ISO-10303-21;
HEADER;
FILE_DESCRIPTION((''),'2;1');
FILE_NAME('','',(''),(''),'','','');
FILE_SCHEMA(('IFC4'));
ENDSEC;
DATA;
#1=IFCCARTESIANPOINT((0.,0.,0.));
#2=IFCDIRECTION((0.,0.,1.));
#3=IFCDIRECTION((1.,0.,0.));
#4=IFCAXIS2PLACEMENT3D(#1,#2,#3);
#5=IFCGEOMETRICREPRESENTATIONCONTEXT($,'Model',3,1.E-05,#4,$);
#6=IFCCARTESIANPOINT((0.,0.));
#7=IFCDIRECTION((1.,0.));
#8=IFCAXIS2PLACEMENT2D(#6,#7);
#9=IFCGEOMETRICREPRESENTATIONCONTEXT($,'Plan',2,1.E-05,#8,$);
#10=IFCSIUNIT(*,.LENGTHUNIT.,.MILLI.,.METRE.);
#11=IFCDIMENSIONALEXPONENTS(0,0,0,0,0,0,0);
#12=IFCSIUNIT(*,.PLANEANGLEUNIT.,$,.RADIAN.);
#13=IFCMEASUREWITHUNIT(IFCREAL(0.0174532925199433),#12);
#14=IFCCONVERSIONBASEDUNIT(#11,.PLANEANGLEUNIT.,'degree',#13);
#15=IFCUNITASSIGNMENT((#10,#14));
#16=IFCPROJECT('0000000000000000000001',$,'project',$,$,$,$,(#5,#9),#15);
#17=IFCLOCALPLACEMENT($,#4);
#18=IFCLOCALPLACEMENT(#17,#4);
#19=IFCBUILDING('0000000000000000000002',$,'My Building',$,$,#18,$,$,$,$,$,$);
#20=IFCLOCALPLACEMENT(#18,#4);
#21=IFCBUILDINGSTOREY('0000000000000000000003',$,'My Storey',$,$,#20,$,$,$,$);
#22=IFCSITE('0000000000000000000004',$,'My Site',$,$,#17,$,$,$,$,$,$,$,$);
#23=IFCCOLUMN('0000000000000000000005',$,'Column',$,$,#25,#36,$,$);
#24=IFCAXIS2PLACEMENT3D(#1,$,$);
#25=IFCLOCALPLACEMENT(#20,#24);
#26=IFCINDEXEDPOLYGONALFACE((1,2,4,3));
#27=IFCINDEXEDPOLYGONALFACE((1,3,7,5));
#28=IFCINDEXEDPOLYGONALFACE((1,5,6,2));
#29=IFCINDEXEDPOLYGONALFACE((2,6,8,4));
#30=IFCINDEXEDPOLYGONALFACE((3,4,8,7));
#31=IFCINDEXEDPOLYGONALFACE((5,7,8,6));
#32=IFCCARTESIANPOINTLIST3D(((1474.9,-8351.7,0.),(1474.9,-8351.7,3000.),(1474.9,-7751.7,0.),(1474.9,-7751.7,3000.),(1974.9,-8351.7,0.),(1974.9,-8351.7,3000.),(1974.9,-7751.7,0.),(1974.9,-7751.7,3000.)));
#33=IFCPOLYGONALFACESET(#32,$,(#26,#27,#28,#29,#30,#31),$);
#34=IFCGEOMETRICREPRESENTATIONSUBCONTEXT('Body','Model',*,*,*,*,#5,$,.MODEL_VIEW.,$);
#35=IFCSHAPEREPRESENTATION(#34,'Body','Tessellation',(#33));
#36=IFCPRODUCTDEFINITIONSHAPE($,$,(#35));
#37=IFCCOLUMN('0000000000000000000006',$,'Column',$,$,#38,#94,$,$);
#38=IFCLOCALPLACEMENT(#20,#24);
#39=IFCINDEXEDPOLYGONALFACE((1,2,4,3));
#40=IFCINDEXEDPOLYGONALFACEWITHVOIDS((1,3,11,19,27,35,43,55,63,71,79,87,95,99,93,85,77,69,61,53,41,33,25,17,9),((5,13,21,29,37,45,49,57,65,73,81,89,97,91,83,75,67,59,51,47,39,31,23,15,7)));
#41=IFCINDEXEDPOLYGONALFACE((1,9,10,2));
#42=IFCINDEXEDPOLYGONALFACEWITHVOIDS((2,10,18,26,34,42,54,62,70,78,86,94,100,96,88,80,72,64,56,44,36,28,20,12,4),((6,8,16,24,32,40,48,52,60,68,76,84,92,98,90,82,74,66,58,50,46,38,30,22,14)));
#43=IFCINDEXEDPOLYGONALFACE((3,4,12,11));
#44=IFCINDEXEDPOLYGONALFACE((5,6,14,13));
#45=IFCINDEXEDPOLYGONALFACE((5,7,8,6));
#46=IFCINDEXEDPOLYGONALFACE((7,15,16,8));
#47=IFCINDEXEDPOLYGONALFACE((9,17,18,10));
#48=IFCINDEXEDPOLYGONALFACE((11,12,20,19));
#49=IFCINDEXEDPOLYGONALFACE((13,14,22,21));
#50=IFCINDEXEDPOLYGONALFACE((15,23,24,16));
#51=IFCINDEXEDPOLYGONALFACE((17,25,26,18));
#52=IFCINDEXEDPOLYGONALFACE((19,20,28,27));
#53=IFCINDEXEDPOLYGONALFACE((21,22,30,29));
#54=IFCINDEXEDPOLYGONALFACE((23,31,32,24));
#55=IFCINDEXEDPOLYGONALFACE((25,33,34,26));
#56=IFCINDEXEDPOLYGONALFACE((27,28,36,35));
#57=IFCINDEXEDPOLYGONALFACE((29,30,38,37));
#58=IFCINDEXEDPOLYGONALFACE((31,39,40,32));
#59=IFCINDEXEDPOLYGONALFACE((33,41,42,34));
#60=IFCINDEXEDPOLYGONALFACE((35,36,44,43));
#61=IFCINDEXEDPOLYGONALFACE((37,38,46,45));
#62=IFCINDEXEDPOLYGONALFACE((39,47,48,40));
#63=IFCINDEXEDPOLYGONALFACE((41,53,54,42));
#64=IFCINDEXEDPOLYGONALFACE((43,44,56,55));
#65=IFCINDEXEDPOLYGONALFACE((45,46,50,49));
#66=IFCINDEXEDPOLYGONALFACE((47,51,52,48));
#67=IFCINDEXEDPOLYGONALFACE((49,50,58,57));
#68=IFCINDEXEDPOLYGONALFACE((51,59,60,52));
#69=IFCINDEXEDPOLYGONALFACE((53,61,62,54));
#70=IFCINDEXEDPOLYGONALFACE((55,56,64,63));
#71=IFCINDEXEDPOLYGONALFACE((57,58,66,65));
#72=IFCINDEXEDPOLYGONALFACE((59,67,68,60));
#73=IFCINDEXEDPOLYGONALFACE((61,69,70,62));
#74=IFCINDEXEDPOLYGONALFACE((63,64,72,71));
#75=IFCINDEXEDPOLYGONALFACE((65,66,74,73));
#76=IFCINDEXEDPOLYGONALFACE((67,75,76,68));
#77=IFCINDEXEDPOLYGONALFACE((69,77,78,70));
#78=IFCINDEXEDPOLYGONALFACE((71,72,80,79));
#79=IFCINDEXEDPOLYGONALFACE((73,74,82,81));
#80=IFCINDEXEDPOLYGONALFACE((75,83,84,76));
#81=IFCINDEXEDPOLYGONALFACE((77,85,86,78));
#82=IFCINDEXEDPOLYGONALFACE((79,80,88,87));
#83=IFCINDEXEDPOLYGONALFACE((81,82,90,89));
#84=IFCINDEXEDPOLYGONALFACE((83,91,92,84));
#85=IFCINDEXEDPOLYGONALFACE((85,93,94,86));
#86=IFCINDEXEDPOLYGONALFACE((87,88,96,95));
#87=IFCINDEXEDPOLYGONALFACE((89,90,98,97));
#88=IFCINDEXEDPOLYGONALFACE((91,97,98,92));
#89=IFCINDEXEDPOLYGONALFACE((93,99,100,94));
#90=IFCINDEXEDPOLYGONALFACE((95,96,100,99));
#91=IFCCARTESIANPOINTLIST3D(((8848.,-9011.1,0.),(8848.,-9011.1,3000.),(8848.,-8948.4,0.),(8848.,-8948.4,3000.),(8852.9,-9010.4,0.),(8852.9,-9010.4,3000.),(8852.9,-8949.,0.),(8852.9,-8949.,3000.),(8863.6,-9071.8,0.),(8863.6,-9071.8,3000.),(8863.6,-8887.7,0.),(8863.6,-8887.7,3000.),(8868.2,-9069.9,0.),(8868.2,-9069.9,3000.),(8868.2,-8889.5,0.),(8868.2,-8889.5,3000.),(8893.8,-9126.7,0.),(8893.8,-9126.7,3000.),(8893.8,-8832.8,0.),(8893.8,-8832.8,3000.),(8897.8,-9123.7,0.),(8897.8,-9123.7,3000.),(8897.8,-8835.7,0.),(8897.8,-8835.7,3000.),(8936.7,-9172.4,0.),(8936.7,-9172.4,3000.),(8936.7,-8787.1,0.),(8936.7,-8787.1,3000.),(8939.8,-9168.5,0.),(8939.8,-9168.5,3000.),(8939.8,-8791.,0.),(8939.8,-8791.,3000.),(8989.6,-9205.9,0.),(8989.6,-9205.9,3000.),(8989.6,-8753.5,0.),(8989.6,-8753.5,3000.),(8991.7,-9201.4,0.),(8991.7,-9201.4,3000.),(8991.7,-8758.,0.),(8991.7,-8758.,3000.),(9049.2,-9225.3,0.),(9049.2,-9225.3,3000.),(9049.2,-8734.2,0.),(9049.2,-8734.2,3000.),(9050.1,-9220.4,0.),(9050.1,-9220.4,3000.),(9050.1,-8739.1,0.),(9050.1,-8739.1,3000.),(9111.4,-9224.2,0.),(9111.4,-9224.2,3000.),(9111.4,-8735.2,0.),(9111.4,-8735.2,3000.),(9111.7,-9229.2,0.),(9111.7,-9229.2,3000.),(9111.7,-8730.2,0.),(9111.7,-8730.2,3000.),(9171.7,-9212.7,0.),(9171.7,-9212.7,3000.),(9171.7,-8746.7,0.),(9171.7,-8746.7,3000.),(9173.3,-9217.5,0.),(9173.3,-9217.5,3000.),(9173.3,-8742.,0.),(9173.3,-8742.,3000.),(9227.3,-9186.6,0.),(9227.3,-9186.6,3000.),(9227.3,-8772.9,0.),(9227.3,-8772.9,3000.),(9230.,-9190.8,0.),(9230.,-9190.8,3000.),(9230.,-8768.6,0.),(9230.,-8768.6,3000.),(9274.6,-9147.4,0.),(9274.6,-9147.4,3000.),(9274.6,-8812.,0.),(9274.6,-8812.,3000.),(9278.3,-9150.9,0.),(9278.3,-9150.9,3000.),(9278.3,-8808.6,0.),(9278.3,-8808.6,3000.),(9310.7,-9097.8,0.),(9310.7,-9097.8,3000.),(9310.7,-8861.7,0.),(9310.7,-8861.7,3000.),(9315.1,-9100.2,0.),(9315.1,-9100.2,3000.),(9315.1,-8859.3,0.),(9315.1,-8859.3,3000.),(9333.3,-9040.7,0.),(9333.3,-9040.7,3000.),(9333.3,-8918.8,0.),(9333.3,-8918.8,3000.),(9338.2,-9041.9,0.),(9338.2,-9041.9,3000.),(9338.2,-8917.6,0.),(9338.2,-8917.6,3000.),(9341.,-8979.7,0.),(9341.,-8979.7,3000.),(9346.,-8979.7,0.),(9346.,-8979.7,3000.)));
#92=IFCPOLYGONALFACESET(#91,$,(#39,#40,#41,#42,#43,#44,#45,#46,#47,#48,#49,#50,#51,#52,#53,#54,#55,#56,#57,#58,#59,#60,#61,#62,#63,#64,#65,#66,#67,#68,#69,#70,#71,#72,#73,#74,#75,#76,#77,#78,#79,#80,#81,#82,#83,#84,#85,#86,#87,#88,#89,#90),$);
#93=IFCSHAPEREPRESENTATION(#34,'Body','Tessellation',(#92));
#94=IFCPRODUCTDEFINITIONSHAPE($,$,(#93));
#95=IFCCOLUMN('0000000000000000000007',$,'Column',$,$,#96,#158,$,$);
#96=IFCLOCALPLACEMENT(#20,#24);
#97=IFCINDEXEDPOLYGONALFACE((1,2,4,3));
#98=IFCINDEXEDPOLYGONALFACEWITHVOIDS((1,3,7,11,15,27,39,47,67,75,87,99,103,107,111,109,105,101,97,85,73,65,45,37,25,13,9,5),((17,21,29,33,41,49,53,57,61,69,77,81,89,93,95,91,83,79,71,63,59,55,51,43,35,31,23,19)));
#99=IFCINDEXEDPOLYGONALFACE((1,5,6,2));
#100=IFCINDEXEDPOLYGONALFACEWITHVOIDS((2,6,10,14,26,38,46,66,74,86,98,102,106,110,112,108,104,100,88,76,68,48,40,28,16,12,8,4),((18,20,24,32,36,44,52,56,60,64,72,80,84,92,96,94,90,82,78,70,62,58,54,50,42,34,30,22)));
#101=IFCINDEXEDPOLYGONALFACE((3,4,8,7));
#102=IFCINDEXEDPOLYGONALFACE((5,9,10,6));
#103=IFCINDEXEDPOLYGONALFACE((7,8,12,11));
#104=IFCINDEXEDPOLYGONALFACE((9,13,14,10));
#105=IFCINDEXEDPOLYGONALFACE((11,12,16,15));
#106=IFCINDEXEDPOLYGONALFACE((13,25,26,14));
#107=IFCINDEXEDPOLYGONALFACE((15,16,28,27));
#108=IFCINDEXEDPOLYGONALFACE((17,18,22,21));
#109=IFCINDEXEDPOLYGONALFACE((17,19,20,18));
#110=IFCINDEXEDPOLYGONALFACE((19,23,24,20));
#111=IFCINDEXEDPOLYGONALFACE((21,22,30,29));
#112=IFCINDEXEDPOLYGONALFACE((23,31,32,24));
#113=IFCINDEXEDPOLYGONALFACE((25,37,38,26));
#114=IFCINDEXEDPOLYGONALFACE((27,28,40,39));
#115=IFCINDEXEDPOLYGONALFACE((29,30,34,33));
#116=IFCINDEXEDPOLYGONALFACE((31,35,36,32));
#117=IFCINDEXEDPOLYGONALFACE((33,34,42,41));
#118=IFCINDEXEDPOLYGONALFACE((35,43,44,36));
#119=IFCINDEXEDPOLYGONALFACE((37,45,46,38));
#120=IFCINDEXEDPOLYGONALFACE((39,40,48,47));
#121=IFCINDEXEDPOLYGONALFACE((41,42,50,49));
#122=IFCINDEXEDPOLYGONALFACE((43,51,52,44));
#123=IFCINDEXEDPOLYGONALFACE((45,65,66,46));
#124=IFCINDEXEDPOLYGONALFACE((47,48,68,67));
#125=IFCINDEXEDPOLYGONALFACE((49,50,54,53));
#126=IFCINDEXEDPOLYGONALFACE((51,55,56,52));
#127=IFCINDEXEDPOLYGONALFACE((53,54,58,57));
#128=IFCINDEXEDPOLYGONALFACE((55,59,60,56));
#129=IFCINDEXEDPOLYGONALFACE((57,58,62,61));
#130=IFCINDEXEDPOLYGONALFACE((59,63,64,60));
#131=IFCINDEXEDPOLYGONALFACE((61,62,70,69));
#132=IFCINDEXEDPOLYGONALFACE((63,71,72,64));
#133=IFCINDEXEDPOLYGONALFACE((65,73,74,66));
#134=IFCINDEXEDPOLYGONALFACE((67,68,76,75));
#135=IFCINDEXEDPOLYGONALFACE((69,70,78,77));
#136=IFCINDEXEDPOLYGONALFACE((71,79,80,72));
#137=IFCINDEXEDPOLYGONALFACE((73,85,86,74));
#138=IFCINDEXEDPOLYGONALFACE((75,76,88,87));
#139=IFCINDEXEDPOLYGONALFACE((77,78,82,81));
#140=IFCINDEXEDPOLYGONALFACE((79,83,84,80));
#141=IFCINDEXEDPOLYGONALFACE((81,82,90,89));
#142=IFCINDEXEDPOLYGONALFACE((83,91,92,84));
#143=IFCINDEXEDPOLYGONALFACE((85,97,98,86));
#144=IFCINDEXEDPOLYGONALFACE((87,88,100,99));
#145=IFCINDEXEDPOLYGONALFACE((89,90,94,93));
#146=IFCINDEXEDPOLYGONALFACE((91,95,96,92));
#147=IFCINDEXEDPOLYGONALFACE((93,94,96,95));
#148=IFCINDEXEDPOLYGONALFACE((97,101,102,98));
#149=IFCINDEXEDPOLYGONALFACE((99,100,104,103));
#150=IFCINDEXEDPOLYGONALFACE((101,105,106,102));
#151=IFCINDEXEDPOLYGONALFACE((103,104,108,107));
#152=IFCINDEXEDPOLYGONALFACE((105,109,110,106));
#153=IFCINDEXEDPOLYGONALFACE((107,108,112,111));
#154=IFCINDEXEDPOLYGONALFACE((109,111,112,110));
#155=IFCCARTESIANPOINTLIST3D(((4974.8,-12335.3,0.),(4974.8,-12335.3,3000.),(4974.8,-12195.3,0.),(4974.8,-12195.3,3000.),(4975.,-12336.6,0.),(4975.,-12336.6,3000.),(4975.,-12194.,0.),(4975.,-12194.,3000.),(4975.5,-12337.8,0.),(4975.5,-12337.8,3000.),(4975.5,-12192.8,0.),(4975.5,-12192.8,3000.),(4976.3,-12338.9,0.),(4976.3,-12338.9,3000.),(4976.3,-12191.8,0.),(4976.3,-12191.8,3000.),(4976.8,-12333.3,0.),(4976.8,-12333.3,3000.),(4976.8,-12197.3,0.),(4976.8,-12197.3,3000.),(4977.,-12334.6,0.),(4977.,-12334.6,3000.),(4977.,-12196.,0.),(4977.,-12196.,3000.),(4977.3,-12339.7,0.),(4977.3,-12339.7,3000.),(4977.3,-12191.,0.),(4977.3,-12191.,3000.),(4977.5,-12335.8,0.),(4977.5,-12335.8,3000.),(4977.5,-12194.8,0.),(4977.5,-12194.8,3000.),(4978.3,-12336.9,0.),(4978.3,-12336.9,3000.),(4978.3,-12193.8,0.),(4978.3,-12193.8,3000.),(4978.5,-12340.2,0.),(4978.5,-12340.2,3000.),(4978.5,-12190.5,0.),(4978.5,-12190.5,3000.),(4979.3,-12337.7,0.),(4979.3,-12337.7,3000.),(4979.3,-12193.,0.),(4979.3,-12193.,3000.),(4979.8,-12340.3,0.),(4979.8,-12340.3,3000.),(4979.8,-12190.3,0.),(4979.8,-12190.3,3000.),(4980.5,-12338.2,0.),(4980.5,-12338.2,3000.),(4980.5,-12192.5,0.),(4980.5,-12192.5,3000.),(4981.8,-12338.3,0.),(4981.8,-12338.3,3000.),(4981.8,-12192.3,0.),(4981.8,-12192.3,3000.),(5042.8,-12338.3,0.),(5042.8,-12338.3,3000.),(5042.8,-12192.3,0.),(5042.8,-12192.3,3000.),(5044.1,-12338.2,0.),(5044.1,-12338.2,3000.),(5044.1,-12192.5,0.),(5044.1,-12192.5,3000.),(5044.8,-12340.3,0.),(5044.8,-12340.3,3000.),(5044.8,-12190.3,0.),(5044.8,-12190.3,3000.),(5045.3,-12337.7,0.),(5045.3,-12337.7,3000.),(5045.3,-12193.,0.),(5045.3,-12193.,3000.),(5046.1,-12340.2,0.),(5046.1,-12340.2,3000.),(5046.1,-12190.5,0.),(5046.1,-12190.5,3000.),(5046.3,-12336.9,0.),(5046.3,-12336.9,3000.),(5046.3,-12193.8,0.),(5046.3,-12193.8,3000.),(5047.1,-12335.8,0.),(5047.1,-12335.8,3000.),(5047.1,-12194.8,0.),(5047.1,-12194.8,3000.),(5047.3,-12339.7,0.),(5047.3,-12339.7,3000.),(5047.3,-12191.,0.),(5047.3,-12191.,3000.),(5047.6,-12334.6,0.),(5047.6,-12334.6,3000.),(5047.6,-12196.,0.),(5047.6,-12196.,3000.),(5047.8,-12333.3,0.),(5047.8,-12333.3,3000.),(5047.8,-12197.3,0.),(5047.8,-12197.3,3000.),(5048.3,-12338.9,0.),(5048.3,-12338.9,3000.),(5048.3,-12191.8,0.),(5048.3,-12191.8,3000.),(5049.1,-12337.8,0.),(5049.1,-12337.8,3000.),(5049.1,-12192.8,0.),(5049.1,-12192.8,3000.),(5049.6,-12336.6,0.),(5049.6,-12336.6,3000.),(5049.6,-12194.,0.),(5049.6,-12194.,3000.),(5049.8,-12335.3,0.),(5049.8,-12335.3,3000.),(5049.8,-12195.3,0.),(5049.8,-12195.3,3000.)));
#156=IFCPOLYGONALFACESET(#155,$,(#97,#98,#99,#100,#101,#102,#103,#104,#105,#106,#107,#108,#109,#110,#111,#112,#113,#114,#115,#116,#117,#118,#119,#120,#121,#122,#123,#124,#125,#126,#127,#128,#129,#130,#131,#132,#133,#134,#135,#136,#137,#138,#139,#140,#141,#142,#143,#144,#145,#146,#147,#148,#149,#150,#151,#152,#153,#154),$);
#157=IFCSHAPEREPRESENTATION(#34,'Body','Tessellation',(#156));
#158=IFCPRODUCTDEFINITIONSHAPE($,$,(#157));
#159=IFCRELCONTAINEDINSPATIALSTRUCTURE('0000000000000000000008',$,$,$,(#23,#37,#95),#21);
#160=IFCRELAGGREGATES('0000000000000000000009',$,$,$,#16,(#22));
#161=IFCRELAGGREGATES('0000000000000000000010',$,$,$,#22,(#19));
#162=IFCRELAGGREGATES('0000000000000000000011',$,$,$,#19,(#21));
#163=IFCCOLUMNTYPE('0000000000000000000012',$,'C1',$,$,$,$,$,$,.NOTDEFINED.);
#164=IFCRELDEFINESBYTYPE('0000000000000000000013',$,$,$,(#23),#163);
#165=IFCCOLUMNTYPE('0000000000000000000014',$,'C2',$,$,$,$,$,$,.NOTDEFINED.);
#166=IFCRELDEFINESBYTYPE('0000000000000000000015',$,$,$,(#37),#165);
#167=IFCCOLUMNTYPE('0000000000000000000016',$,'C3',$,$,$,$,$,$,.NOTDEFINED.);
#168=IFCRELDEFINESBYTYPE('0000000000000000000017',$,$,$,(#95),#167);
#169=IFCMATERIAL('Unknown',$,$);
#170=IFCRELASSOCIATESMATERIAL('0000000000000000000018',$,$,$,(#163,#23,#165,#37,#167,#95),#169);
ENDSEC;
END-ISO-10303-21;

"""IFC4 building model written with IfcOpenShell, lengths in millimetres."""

from ifc_helpers import new_model, entity, si_unit, converted_unit, frame, origin_with_axes, origin_2d_with_axis, place, context, subcontext, project, spatial, rectangle, hollow_rectangle, hollow_circle, extrude, material, material_profile, profile_set, profile_usage, type_object, element, save


model = new_model("IFC4")

# Units and contexts
model_context = context("Model", 3, precision=1e-05, world=origin_with_axes())
plan_context = context("Plan", 2, precision=1e-05, world=origin_2d_with_axis())
body_context_1 = subcontext(model_context, "Body", "Model", "MODEL_VIEW")
ifc_project = project(units=[si_unit("LENGTHUNIT", "METRE", prefix="MILLI"), converted_unit("PLANEANGLEUNIT", "degree", entity("IfcReal", 0.0174532925199433), si_unit("PLANEANGLEUNIT", "RADIAN"), dimensions=[0, 0, 0, 0, 0, 0, 0])], contexts=[model_context, plan_context])

# Site, building, storey
site_placement = place(None, origin_with_axes())
site = spatial("IfcSite", under=ifc_project, at=site_placement, Name="My Site")
building_placement = place(site_placement, origin_with_axes())
building = spatial("IfcBuilding", under=site, at=building_placement, Name="My Building")
storey_placement = place(building_placement, origin_with_axes())
storey = spatial("IfcBuildingStorey", under=building, at=storey_placement, Name="My Storey")

# Columns
ifc_material = material(Name="Unknown")
ifc_material_profile_1 = material_profile(ifc_material, rectangle(XDim=500.0, YDim=600.0))
ifc_profile_set_1 = profile_set([ifc_material_profile_1])
ifc_profile_usage_1 = profile_usage(ifc_profile_set_1)
column_type_1 = type_object("IfcColumnType", Name="C1", PredefinedType="NOTDEFINED", material=ifc_profile_set_1)
column_1_placement = place(storey_placement, frame((1724.9, -8051.7, 0.0), z_axis=(0.0, 0.0, 1.0), x_axis=(1.0, 0.0, 0.0)))
element("IfcColumn", 1, at=column_1_placement, inside=storey, type_object=column_type_1, material=ifc_profile_usage_1, Name="Column", context=body_context_1, shape_type="SweptSolid", body=[
    extrude(rectangle(XDim=500.0, YDim=600.0), origin_with_axes(), (0.0, 0.0, 1.0), 3000.0),
])
ifc_material_profile_2 = material_profile(ifc_material, hollow_circle(Radius=250.0, WallThickness=5.0))
ifc_profile_set_2 = profile_set([ifc_material_profile_2])
ifc_profile_usage_2 = profile_usage(ifc_profile_set_2, cardinal=5)
column_type_2 = type_object("IfcColumnType", Name="C2", PredefinedType="NOTDEFINED", material=ifc_profile_set_2)
column_2_placement = place(storey_placement, frame((9096.0, -8979.7, 0.0), z_axis=(0.0, 0.0, 1.0), x_axis=(1.0, 0.0, 0.0)))
element("IfcColumn", 2, at=column_2_placement, inside=storey, type_object=column_type_2, material=ifc_profile_usage_2, Name="Column", context=body_context_1, shape_type="SweptSolid", body=[
    extrude(hollow_circle(Radius=250.0, WallThickness=5.0), origin_with_axes(), (0.0, 0.0, 1.0), 3000.0),
])
ifc_material_profile_3 = material_profile(ifc_material, hollow_rectangle(XDim=75.0, YDim=150.0, WallThickness=2.0, InnerFilletRadius=5.0, OuterFilletRadius=5.0))
ifc_profile_set_3 = profile_set([ifc_material_profile_3])
ifc_profile_usage_3 = profile_usage(ifc_profile_set_3)
column_type_3 = type_object("IfcColumnType", Name="C3", PredefinedType="NOTDEFINED", material=ifc_profile_set_3)
column_3_placement = place(storey_placement, frame((5012.3, -12265.3, 0.0), z_axis=(0.0, 0.0, 1.0), x_axis=(1.0, 0.0, 0.0)))
element("IfcColumn", 3, at=column_3_placement, inside=storey, type_object=column_type_3, material=ifc_profile_usage_3, Name="Column", context=body_context_1, shape_type="SweptSolid", body=[
    extrude(hollow_rectangle(XDim=75.0, YDim=150.0, WallThickness=2.0, InnerFilletRadius=5.0, OuterFilletRadius=5.0), origin_with_axes(), (0.0, 0.0, 1.0), 3000.0),
])

save(model, "model.ifc")
